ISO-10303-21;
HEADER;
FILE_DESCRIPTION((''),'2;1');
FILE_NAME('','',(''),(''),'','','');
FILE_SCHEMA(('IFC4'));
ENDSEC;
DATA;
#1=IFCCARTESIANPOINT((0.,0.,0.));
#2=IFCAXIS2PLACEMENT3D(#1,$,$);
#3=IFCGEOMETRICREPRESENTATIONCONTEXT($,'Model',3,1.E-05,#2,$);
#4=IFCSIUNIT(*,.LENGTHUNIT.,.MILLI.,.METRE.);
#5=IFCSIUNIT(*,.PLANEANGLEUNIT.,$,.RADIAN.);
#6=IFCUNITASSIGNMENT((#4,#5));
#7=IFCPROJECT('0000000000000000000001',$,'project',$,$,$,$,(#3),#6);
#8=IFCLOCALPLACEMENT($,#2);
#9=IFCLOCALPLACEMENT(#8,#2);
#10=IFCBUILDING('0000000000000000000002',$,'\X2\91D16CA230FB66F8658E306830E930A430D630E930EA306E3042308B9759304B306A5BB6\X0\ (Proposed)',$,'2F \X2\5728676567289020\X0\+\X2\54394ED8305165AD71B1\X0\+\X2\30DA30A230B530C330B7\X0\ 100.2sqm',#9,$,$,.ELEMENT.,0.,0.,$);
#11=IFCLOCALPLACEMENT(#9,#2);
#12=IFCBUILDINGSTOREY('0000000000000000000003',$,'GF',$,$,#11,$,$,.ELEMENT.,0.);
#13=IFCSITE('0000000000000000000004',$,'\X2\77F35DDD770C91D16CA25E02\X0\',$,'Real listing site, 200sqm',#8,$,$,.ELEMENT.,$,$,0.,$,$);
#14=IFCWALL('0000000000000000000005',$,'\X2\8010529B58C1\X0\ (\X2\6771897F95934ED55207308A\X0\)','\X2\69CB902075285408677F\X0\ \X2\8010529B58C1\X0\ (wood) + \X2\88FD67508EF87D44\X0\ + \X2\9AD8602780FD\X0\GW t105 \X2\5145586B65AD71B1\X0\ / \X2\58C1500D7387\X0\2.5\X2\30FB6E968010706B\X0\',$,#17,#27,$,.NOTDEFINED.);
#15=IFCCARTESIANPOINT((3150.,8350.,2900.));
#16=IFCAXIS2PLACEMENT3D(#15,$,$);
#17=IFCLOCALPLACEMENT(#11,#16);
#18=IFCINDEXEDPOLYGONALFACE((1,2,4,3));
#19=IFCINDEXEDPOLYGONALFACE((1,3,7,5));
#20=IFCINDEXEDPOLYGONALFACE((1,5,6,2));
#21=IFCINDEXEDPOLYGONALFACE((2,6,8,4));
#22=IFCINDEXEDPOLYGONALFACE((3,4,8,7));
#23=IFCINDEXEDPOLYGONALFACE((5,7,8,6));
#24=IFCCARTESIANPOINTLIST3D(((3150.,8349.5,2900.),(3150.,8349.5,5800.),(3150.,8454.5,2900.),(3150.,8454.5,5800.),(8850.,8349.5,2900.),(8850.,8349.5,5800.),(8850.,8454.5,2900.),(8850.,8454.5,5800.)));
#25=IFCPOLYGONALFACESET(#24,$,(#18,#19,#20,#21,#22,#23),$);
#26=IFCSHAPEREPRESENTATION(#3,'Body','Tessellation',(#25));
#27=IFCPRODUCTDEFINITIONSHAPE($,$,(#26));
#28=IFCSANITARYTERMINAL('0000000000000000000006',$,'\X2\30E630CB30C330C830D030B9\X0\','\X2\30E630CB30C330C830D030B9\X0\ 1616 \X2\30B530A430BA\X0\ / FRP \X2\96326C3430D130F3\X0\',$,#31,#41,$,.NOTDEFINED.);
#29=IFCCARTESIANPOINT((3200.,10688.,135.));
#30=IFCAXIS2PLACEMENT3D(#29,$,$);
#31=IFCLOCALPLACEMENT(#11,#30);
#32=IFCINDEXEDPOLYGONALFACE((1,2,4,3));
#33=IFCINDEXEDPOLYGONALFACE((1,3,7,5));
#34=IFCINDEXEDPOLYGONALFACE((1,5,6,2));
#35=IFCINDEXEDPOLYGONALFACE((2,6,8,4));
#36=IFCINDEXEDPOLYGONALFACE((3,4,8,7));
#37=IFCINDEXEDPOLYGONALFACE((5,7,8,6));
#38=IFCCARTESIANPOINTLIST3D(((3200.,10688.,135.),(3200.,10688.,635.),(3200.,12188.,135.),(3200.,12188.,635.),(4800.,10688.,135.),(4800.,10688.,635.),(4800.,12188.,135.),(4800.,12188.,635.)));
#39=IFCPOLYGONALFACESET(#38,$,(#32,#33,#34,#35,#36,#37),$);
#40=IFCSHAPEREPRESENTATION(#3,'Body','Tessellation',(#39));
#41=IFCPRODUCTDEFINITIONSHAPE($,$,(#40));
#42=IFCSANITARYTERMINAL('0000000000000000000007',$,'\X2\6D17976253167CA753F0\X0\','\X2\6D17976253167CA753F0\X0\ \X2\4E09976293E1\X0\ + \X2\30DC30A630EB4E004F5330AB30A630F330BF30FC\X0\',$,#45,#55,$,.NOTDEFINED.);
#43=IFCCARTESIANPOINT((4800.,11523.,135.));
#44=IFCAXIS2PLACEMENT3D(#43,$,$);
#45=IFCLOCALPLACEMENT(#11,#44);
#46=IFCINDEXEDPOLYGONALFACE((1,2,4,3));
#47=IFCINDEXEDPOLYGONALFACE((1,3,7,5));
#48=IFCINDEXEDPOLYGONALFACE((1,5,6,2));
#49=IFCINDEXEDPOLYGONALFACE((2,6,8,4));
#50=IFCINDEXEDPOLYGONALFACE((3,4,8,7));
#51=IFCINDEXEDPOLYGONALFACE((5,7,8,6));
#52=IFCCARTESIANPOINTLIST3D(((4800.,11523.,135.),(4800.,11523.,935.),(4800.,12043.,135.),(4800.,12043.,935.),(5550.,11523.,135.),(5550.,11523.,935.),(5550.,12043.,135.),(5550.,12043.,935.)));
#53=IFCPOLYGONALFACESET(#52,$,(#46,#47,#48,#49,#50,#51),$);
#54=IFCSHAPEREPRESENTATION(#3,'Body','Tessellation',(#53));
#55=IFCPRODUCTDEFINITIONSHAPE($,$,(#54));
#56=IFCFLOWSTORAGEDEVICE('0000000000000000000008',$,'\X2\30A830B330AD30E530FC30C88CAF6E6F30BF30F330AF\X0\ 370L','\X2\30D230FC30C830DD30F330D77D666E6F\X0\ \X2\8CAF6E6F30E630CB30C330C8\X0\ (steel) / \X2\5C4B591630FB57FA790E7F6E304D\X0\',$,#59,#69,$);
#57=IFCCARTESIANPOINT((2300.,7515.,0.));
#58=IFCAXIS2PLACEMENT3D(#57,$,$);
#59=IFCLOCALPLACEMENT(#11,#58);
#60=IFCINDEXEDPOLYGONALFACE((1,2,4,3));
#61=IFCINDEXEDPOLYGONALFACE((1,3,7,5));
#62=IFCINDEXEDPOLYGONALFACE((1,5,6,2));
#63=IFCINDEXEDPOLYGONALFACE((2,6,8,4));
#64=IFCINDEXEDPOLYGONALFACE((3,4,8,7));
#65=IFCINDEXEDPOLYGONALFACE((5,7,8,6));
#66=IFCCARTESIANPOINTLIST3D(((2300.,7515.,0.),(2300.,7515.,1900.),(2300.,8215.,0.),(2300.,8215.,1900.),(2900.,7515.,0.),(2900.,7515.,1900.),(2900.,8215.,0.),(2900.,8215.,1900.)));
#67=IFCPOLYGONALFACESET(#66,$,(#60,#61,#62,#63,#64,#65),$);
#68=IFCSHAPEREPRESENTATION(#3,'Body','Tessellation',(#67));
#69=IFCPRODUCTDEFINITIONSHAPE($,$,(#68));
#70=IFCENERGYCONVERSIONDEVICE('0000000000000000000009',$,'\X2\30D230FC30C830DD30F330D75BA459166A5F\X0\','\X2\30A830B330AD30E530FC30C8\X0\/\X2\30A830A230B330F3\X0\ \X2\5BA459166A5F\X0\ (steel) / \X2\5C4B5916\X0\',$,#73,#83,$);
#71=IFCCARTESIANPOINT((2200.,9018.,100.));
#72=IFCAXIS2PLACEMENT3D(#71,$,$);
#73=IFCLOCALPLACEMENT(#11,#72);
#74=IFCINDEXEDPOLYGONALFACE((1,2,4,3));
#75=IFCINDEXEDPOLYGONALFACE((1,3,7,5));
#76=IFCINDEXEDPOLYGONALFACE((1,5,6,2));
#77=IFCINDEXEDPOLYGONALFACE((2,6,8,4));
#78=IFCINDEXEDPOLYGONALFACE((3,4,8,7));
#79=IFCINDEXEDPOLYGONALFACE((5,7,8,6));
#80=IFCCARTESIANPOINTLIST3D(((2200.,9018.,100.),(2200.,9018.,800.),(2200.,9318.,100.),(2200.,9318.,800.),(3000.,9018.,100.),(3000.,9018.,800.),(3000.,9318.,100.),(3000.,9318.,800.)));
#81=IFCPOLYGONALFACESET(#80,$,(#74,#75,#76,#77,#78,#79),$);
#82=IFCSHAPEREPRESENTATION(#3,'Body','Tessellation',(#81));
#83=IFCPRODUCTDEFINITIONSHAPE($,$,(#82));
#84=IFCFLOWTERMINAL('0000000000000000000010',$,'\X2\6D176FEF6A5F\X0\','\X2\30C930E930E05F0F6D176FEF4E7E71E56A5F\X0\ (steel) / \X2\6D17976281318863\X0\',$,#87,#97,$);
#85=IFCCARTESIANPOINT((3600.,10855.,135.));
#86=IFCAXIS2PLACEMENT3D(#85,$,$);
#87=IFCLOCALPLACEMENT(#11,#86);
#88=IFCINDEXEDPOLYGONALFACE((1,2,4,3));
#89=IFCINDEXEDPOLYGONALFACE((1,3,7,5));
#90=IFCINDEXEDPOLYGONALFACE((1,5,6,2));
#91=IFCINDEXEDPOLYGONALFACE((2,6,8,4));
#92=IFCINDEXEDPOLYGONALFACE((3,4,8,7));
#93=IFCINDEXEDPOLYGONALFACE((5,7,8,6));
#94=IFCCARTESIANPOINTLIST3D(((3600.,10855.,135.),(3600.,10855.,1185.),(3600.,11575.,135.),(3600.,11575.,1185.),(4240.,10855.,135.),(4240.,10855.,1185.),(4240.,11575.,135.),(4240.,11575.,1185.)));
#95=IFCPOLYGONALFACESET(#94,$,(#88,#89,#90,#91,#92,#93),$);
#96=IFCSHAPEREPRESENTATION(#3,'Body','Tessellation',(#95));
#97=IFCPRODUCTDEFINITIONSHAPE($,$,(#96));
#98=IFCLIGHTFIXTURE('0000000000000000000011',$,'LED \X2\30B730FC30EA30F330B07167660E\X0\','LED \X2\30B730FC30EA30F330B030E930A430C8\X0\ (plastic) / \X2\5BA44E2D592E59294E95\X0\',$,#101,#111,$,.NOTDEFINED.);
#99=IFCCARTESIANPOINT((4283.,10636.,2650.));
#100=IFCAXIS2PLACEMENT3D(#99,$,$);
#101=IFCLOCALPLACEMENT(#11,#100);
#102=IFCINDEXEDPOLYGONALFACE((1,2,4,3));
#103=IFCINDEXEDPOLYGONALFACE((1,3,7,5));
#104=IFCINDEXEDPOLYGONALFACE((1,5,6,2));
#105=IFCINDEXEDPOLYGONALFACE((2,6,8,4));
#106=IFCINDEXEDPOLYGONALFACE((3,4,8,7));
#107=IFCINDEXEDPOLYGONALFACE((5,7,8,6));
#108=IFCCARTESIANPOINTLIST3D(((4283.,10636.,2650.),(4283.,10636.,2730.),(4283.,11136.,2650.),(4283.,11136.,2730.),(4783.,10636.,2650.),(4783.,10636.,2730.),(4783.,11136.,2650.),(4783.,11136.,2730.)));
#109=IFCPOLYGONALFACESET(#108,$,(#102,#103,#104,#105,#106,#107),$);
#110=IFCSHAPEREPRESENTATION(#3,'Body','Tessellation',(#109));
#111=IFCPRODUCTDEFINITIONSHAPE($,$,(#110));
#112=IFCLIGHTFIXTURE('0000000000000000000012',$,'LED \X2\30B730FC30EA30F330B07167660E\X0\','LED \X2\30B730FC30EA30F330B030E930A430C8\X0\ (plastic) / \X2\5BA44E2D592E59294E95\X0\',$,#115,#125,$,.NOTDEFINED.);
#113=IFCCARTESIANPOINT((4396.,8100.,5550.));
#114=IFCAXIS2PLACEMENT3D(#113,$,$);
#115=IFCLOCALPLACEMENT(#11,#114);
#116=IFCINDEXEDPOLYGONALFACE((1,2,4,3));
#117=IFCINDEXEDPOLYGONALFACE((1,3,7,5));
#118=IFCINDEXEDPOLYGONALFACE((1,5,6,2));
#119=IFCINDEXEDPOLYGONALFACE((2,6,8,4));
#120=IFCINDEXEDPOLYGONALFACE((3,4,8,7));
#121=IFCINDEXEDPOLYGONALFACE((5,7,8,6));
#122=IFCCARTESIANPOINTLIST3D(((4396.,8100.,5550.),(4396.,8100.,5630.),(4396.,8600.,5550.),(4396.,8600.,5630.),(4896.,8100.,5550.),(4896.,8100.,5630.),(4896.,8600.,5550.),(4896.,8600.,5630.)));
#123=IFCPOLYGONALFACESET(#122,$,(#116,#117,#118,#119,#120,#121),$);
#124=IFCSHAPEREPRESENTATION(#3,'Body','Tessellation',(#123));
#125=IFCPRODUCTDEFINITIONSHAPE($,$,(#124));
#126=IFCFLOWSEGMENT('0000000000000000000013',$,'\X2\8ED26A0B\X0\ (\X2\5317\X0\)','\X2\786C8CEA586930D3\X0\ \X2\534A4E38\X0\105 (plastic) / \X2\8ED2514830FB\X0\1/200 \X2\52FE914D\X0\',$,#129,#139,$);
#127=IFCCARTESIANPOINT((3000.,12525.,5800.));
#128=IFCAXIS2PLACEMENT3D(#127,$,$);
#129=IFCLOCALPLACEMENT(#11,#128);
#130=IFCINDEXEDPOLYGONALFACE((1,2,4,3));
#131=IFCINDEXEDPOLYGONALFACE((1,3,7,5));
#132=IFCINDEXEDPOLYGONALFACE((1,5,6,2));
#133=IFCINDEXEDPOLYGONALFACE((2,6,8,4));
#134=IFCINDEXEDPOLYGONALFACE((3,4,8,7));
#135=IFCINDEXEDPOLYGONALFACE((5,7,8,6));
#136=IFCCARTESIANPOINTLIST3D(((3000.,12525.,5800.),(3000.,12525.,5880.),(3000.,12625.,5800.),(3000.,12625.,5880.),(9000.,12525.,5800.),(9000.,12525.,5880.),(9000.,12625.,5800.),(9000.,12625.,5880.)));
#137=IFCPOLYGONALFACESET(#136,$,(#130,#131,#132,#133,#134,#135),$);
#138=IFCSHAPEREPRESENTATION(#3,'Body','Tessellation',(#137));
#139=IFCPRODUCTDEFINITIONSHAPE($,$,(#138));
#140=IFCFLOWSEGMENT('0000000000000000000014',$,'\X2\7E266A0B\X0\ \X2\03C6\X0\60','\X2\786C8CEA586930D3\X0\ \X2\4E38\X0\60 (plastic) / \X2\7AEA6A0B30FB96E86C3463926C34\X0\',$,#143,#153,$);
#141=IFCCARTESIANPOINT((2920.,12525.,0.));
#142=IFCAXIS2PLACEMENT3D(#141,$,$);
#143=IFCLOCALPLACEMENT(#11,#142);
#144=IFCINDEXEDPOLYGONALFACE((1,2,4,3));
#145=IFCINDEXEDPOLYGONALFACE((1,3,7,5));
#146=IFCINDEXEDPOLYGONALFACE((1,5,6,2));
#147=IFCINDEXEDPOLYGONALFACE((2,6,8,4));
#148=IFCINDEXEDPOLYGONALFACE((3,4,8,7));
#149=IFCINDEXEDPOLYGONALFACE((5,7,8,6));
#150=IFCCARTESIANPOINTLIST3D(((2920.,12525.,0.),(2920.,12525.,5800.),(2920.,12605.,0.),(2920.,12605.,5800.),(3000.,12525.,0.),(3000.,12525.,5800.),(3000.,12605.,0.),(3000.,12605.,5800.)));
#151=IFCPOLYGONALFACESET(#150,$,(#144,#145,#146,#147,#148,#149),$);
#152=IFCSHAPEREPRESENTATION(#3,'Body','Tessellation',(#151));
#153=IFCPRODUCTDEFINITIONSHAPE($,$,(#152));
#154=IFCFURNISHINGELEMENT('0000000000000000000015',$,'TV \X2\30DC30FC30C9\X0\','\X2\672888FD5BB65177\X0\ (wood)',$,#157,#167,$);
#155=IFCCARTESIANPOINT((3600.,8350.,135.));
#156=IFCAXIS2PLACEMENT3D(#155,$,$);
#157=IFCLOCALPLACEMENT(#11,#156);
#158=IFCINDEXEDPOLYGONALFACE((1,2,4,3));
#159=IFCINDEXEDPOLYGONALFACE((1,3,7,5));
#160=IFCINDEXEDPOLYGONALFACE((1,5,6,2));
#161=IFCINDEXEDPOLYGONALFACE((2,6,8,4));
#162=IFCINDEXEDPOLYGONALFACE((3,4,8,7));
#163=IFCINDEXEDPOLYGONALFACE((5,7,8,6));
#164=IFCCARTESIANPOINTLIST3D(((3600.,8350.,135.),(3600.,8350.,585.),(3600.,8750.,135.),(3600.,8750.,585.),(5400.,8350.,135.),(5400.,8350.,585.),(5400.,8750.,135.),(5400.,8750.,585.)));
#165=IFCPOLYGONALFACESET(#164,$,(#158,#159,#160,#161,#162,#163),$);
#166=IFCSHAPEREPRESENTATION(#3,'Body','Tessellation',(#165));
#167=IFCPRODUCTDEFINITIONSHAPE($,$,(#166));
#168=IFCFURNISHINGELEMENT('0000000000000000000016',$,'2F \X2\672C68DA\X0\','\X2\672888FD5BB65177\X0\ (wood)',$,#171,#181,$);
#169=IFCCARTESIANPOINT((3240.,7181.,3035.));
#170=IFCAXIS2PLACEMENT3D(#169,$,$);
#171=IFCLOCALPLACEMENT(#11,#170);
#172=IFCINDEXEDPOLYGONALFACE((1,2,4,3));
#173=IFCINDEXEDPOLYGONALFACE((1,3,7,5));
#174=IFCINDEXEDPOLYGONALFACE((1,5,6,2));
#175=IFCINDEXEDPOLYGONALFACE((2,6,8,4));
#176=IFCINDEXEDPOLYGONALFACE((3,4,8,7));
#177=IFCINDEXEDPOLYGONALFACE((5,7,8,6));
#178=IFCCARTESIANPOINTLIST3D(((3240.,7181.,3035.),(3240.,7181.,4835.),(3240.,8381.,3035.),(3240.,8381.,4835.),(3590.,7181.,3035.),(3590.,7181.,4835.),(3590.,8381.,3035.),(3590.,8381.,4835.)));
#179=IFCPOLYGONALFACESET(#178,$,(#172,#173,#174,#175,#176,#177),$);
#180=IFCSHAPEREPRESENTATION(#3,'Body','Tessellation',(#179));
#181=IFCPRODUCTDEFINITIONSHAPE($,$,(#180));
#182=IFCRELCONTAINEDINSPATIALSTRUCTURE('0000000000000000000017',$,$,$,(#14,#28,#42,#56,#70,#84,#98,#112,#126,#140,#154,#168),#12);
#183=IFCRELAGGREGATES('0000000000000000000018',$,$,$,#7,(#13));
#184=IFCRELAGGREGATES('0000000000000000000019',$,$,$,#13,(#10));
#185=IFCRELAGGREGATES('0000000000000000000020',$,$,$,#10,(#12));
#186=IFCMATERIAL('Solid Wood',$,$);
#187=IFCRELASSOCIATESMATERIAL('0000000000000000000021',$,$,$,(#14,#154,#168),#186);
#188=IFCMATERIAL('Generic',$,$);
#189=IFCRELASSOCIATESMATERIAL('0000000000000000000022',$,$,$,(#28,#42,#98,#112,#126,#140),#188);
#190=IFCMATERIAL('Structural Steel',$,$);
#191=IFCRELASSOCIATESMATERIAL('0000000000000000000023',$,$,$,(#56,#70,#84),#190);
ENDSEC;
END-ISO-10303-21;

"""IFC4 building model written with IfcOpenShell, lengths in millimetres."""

from ifc_helpers import new_model, si_unit, frame, frame_2d, origin, place, context, project, spatial, rectangle, extrude, material, element, save


model = new_model("IFC4")

# Units and contexts
model_context = context("Model", 3, precision=1e-05, world=origin())
ifc_project = project(units=[si_unit("LENGTHUNIT", "METRE", prefix="MILLI"), si_unit("PLANEANGLEUNIT", "RADIAN")], contexts=[model_context])

# Site, building, storey
site_placement = place(None, origin())
site = spatial("IfcSite", under=ifc_project, at=site_placement, Name="石川県金沢市", ObjectType="Real listing site, 200sqm", CompositionType="ELEMENT", RefElevation=0.0)
building_placement = place(site_placement, origin())
building = spatial("IfcBuilding", under=site, at=building_placement, Name="金沢・書斎とライブラリのある静かな家 (Proposed)", ObjectType="2F 在来木造+吹付け断熱+ペアサッシ 100.2sqm", CompositionType="ELEMENT", ElevationOfRefHeight=0.0, ElevationOfTerrain=0.0)
storey_placement = place(building_placement, origin())
storey = spatial("IfcBuildingStorey", under=building, at=storey_placement, Name="GF", CompositionType="ELEMENT", Elevation=0.0)

# Shared definitions
ifc_material_1 = material(Name="Solid Wood")

# Wall
wall_1_placement = place(storey_placement, frame((3150.0, 8350.0, 2900.0)))
element("IfcWall", 1, at=wall_1_placement, inside=storey, material=ifc_material_1, Name="耐力壁 (東西間仕切り)", Description="構造用合板 耐力壁 (wood) + 製材軸組 + 高性能GW t105 充填断熱 / 壁倍率2.5・準耐火", PredefinedType="NOTDEFINED", context=model_context, shape_type="SweptSolid", body=[
    extrude(rectangle(XDim=5700.0, YDim=105.0, at=frame_2d((2850.0, 52.0))), frame((3150.0, 8350.0, 2900.0)), (0.0, 0.0, 1.0), 2900.0),
])

# Sanitary terminals
ifc_material_2 = material(Name="Generic")
sanitary_terminal_1_placement = place(storey_placement, frame((3200.0, 10688.0, 135.0)))
element("IfcSanitaryTerminal", 2, at=sanitary_terminal_1_placement, inside=storey, material=ifc_material_2, Name="ユニットバス", Description="ユニットバス 1616 サイズ / FRP 防水パン", PredefinedType="NOTDEFINED", context=model_context, shape_type="SweptSolid", body=[
    extrude(rectangle(XDim=1600.0, YDim=1500.0, at=frame_2d((800.0, 750.0))), frame((3200.0, 10688.0, 135.0)), (0.0, 0.0, 1.0), 500.0),
])
sanitary_terminal_2_placement = place(storey_placement, frame((4800.0, 11523.0, 135.0)))
element("IfcSanitaryTerminal", 3, at=sanitary_terminal_2_placement, inside=storey, material=ifc_material_2, Name="洗面化粧台", Description="洗面化粧台 三面鏡 + ボウル一体カウンター", PredefinedType="NOTDEFINED", context=model_context, shape_type="SweptSolid", body=[
    extrude(rectangle(XDim=750.0, YDim=520.0, at=frame_2d((375.0, 260.0))), frame((4800.0, 11523.0, 135.0)), (0.0, 0.0, 1.0), 800.0),
])

# Flow storage device
ifc_material_3 = material(Name="Structural Steel")
flow_storage_device_placement = place(storey_placement, frame((2300.0, 7515.0, 0.0)))
element("IfcFlowStorageDevice", 4, at=flow_storage_device_placement, inside=storey, material=ifc_material_3, Name="エコキュート貯湯タンク 370L", Description="ヒートポンプ給湯 貯湯ユニット (steel) / 屋外・基礎置き", context=model_context, shape_type="SweptSolid", body=[
    extrude(rectangle(XDim=600.0, YDim=700.0, at=frame_2d((300.0, 350.0))), frame((2300.0, 7515.0, 0.0)), (0.0, 0.0, 1.0), 1900.0),
])

# Energy conversion device
energy_conversion_device_placement = place(storey_placement, frame((2200.0, 9018.0, 100.0)))
element("IfcEnergyConversionDevice", 5, at=energy_conversion_device_placement, inside=storey, material=ifc_material_3, Name="ヒートポンプ室外機", Description="エコキュート/エアコン 室外機 (steel) / 屋外", context=model_context, shape_type="SweptSolid", body=[
    extrude(rectangle(XDim=800.0, YDim=300.0, at=frame_2d((400.0, 150.0))), frame((2200.0, 9018.0, 100.0)), (0.0, 0.0, 1.0), 700.0),
])

# Flow terminal
flow_terminal_placement = place(storey_placement, frame((3600.0, 10855.0, 135.0)))
element("IfcFlowTerminal", 6, at=flow_terminal_placement, inside=storey, material=ifc_material_3, Name="洗濯機", Description="ドラム式洗濯乾燥機 (steel) / 洗面脱衣", context=model_context, shape_type="SweptSolid", body=[
    extrude(rectangle(XDim=640.0, YDim=720.0, at=frame_2d((320.0, 360.0))), frame((3600.0, 10855.0, 135.0)), (0.0, 0.0, 1.0), 1050.0),
])

# Light fixtures
light_fixture_1_placement = place(storey_placement, frame((4283.0, 10636.0, 2650.0)))
element("IfcLightFixture", 7, at=light_fixture_1_placement, inside=storey, material=ifc_material_2, Name="LED シーリング照明", Description="LED シーリングライト (plastic) / 室中央天井", PredefinedType="NOTDEFINED", context=model_context, shape_type="SweptSolid", body=[
    extrude(rectangle(XDim=500.0, YDim=500.0, at=frame_2d((250.0, 250.0))), frame((4283.0, 10636.0, 2650.0)), (0.0, 0.0, 1.0), 80.0),
])
light_fixture_2_placement = place(storey_placement, frame((4396.0, 8100.0, 5550.0)))
element("IfcLightFixture", 8, at=light_fixture_2_placement, inside=storey, material=ifc_material_2, Name="LED シーリング照明", Description="LED シーリングライト (plastic) / 室中央天井", PredefinedType="NOTDEFINED", context=model_context, shape_type="SweptSolid", body=[
    extrude(rectangle(XDim=500.0, YDim=500.0, at=frame_2d((250.0, 250.0))), frame((4396.0, 8100.0, 5550.0)), (0.0, 0.0, 1.0), 80.0),
])

# Flow segments
flow_segment_1_placement = place(storey_placement, frame((3000.0, 12525.0, 5800.0)))
element("IfcFlowSegment", 9, at=flow_segment_1_placement, inside=storey, material=ifc_material_2, Name="軒樋 (北)", Description="硬質塩ビ 半丸105 (plastic) / 軒先・1/200 勾配", context=model_context, shape_type="SweptSolid", body=[
    extrude(rectangle(XDim=6000.0, YDim=100.0, at=frame_2d((3000.0, 50.0))), frame((3000.0, 12525.0, 5800.0)), (0.0, 0.0, 1.0), 80.0),
])
flow_segment_2_placement = place(storey_placement, frame((2920.0, 12525.0, 0.0)))
element("IfcFlowSegment", 10, at=flow_segment_2_placement, inside=storey, material=ifc_material_2, Name="縦樋 φ60", Description="硬質塩ビ 丸60 (plastic) / 竪樋・雨水排水", context=model_context, shape_type="SweptSolid", body=[
    extrude(rectangle(XDim=80.0, YDim=80.0, at=frame_2d((40.0, 40.0))), frame((2920.0, 12525.0, 0.0)), (0.0, 0.0, 1.0), 5800.0),
])

# Furnishing elements
furnishing_1_placement = place(storey_placement, frame((3600.0, 8350.0, 135.0)))
element("IfcFurnishingElement", 11, at=furnishing_1_placement, inside=storey, material=ifc_material_1, Name="TV ボード", Description="木製家具 (wood)", context=model_context, shape_type="SweptSolid", body=[
    extrude(rectangle(XDim=1800.0, YDim=400.0, at=frame_2d((900.0, 200.0))), frame((3600.0, 8350.0, 135.0)), (0.0, 0.0, 1.0), 450.0),
])
furnishing_2_placement = place(storey_placement, frame((3240.0, 7181.0, 3035.0)))
element("IfcFurnishingElement", 12, at=furnishing_2_placement, inside=storey, material=ifc_material_1, Name="2F 本棚", Description="木製家具 (wood)", context=model_context, shape_type="SweptSolid", body=[
    extrude(rectangle(XDim=350.0, YDim=1200.0, at=frame_2d((175.0, 600.0))), frame((3240.0, 7181.0, 3035.0)), (0.0, 0.0, 1.0), 1800.0),
])

save(model, "model.ifc")
